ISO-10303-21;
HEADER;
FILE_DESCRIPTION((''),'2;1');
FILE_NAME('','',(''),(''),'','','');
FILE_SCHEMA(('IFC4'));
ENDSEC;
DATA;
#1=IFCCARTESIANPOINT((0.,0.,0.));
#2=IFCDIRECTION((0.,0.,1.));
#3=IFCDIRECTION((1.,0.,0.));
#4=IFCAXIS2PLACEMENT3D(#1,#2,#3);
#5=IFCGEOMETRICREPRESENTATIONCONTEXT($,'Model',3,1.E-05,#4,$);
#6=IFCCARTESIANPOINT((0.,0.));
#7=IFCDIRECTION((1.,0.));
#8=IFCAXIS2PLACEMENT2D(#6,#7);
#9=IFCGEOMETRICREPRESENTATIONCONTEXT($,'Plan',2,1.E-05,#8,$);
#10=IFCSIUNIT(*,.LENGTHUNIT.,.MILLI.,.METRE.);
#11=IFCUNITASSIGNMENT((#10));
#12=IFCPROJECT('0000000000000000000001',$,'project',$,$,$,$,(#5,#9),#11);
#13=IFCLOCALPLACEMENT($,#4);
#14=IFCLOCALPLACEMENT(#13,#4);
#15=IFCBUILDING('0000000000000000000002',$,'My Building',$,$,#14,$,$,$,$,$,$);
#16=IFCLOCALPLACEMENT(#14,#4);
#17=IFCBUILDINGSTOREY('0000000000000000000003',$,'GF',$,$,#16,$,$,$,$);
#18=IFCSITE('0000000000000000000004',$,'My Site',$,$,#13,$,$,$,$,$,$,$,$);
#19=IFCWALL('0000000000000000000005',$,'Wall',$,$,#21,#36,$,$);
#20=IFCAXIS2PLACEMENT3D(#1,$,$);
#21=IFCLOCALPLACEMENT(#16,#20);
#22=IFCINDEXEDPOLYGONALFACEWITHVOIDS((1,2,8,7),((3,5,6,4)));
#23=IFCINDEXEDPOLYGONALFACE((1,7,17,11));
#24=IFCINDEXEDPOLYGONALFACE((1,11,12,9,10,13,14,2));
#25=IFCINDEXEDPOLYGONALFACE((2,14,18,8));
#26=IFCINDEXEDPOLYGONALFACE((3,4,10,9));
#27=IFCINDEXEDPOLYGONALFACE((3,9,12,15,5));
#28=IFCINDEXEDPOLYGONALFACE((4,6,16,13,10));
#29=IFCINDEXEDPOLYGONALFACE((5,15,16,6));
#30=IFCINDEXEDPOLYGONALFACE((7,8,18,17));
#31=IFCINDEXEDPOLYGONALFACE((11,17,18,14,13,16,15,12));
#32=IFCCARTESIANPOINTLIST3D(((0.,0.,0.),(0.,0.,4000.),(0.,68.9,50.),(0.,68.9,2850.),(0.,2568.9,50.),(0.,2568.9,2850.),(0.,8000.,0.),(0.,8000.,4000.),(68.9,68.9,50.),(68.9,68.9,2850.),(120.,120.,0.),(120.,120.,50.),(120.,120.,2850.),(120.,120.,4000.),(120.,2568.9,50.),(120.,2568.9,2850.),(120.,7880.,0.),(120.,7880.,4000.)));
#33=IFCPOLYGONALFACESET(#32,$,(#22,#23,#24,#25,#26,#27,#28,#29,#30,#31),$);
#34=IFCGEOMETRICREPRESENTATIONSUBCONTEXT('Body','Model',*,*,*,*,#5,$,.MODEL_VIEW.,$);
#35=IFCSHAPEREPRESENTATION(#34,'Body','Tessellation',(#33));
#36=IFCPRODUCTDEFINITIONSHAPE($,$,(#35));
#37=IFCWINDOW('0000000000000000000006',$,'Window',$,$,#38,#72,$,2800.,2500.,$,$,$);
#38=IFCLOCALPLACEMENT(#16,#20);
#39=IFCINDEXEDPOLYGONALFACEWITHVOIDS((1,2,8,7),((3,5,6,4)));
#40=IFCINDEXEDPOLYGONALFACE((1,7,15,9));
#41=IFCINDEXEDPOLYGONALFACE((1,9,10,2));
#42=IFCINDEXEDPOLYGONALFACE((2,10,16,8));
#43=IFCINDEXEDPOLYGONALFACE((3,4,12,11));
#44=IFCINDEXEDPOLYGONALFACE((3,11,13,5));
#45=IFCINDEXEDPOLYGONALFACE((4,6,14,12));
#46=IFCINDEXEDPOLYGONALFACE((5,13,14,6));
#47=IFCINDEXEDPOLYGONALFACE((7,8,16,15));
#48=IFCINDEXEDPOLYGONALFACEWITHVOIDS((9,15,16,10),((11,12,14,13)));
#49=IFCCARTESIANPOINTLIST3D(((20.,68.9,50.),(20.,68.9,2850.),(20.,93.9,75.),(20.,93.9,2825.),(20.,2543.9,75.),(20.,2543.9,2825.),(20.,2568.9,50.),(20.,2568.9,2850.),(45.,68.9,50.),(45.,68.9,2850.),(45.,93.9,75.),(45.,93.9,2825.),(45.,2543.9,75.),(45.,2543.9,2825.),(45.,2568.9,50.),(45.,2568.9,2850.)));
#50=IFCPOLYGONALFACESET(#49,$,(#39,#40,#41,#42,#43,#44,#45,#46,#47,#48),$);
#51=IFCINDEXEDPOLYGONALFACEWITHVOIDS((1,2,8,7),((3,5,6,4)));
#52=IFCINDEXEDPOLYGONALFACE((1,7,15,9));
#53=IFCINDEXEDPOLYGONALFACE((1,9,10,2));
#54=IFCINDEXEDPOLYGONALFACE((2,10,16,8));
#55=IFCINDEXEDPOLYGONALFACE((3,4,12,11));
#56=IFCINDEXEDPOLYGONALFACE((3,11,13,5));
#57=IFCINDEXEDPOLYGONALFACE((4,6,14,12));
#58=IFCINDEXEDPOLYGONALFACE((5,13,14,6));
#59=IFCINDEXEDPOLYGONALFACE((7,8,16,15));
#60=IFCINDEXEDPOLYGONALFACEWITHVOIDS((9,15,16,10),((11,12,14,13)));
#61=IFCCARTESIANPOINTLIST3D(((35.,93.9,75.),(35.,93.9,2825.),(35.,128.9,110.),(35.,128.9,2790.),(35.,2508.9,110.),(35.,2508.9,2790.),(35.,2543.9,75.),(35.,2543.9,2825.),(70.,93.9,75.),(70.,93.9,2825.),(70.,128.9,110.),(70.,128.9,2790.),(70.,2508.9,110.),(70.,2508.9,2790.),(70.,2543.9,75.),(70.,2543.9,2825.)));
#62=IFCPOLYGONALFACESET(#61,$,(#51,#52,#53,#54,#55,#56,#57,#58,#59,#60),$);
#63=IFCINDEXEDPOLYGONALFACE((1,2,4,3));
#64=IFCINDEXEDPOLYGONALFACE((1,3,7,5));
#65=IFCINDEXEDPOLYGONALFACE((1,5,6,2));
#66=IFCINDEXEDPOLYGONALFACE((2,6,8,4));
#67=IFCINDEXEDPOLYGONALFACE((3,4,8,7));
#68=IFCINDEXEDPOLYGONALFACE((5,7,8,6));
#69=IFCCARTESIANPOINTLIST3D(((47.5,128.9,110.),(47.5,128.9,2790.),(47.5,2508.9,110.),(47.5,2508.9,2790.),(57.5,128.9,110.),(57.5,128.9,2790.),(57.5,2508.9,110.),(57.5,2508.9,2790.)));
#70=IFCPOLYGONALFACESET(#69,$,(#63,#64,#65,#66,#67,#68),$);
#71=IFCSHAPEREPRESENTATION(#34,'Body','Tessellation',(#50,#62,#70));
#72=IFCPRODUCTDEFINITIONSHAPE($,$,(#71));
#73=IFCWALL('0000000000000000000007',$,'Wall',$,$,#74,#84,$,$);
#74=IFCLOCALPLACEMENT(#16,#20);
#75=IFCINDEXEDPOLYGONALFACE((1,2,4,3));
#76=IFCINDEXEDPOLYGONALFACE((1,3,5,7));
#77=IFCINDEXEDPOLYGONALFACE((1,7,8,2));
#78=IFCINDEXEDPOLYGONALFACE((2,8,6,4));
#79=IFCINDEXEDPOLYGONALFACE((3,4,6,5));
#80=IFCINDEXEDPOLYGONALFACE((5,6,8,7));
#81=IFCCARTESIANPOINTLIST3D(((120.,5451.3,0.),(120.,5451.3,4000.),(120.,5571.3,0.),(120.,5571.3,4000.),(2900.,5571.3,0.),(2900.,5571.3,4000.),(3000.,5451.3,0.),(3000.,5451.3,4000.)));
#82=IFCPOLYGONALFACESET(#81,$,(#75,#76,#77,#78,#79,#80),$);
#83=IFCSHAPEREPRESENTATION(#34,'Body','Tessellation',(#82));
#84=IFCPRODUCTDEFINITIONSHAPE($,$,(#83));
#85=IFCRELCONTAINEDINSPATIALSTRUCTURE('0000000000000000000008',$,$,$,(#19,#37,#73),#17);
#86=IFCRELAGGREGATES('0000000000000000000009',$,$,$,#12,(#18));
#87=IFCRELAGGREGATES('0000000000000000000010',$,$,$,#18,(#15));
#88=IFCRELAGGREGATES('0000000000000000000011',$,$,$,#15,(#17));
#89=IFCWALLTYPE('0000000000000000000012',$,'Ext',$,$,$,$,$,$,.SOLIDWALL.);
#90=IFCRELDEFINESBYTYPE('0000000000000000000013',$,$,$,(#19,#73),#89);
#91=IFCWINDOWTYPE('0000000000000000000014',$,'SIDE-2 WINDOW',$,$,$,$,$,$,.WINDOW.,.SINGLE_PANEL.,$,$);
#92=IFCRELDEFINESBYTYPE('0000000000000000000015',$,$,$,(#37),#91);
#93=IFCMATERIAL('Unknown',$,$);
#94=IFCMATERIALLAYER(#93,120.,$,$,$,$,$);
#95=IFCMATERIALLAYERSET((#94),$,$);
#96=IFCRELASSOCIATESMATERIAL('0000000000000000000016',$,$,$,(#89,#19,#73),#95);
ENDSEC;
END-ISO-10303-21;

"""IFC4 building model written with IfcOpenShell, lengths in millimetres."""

from ifc_helpers import new_model, entity, si_unit, frame, origin_with_axes, origin_2d_with_axis, place, context, subcontext, project, spatial, line, indexed_curve, outline, extrude, shape, source, transform, mapped, material, layer, layer_set, layer_usage, type_object, type_shapes, element, fill, save


model = new_model("IFC4")

# Units and contexts
model_context = context("Model", 3, precision=1e-05, world=origin_with_axes())
plan_context = context("Plan", 2, precision=1e-05, world=origin_2d_with_axis())
body_context_1 = subcontext(model_context, "Body", "Model", "MODEL_VIEW")
body_context_2 = subcontext(plan_context, "Body", "Plan", "PLAN_VIEW")
ifc_project = project(units=[si_unit("LENGTHUNIT", "METRE", prefix="MILLI")], contexts=[model_context, plan_context])

# Site, building, storey
site_placement = place(None, origin_with_axes())
site = spatial("IfcSite", under=ifc_project, at=site_placement, Name="My Site")
building_placement = place(site_placement, origin_with_axes())
building = spatial("IfcBuilding", under=site, at=building_placement, Name="My Building")
storey_placement = place(building_placement, origin_with_axes())
storey = spatial("IfcBuildingStorey", under=building, at=storey_placement, Name="GF")

# Shared definitions
ifc_material = material(Name="Unknown")

# Shared definitions
ifc_layer_1 = layer(ifc_material, 120.0)
ifc_layer_set_1 = layer_set([ifc_layer_1])
wall_type_1 = type_object("IfcWallType", Name="Ext", PredefinedType="SOLIDWALL", material=ifc_layer_set_1)

# Wall, opening, window
ifc_layer_usage_1 = layer_usage(ifc_layer_set_1, "AXIS2", "NEGATIVE", 0.0)
wall_1_placement = place(storey_placement, frame((120.0, 8000.0, 0.0), z_axis=(0.0, 0.0, 1.0), x_axis=(0.0, -1.0, 0.0)))
wall_1 = element("IfcWall", 1, at=wall_1_placement, inside=storey, type_object=wall_type_1, material=ifc_layer_usage_1, Name="Wall", context=body_context_1, shape_type="SweptSolid", body=[
    extrude(outline(indexed_curve([(0.0, -120.0), (120.0, 0.0), (7880.0, 0.0), (8000.0, -120.0)], segments=[line(1, 2, 3, 4, 1)])), origin_with_axes(), (0.0, 0.0, 1.0), 4000.0),
])
shared_shape_1 = source(origin_with_axes(), body_context_1, "Body", "SweptSolid", [
    extrude(outline(indexed_curve([(0.0, 0.0), (2500.0, 0.0), (2500.0, 2800.0), (0.0, 2800.0)], segments=[line(1, 2, 3, 4, 1)])), frame((0.0, -600.0, 0.0), z_axis=(0.0, -1.0, 0.0), x_axis=(1.0, 0.0, 0.0)), (0.0, 0.0, -1.0), 1200.0),
])
opening_1_placement = place(wall_1_placement, frame((5431.1, -100.0, 50.0), z_axis=(0.0, 0.0, 1.0), x_axis=(1.0, 0.0, 0.0)))
opening_1 = element("IfcOpeningElement", 2, at=opening_1_placement, cuts=wall_1, PredefinedType="OPENING", context=body_context_1, shape_type="MappedRepresentation", body=[
    mapped(shared_shape_1, transform((0.0, 0.0, 0.0), x_axis=(1.0, 0.0, 0.0), y_axis=(0.0, 1.0, 0.0), z_axis=(0.0, 0.0, 1.0), scale=1.0)),
])
window_type_1 = type_object("IfcWindowType", Name="SIDE-2 WINDOW", PartitioningType="SINGLE_PANEL", PredefinedType="WINDOW")
shared_shape_2 = source(origin_with_axes(), body_context_1, "Body", "SweptSolid", [
    extrude(outline(indexed_curve([(0.0, 0.0), (2500.0, 0.0), (2500.0, 2800.0), (0.0, 2800.0)], segments=[line(1, 2, 3, 4, 1)]), holes=[indexed_curve([(25.0, 25.0), (2475.0, 25.0), (2475.0, 2775.0), (25.0, 2775.0)], segments=[line(1, 2, 3, 4, 1)])]), frame((0.0, 0.0, 0.0), z_axis=(0.0, -1.0, 0.0), x_axis=(1.0, 0.0, 0.0)), (0.0, 0.0, -1.0), 25.0),
    extrude(outline(indexed_curve([(0.0, 0.0), (2450.0, 0.0), (2450.0, 2750.0), (0.0, 2750.0)], segments=[line(1, 2, 3, 4, 1)]), holes=[indexed_curve([(35.0, 35.0), (2415.0, 35.0), (2415.0, 2715.0), (35.0, 2715.0)], segments=[line(1, 2, 3, 4, 1)])]), frame((25.0, 15.0, 25.0), z_axis=(0.0, -1.0, 0.0), x_axis=(1.0, 0.0, 0.0)), (0.0, 0.0, -1.0), 35.0),
    extrude(outline(indexed_curve([(35.0, 35.0), (2415.0, 35.0), (2415.0, 2715.0), (35.0, 2715.0)], segments=[line(1, 2, 3, 4, 1)])), frame((25.0, 27.5, 25.0), z_axis=(0.0, -1.0, 0.0), x_axis=(1.0, 0.0, 0.0)), (0.0, 0.0, -1.0), 10.0),
])
shared_shape_3 = source(origin_with_axes(), body_context_2, "Body", "Curve2D", [
    entity("IfcIndexedPolyCurve", entity("IfcCartesianPointList2D", [[25.0, 0.0], [2475.0, 0.0]])),
    entity("IfcIndexedPolyCurve", entity("IfcCartesianPointList2D", [[0.0, 25.0], [25.0, 25.0], [25.0, 0.0], [0.0, 0.0]]), [entity("IfcLineIndex", [1, 2, 3, 4, 1])]),
    entity("IfcIndexedPolyCurve", entity("IfcCartesianPointList2D", [[2500.0, 25.0], [2475.0, 25.0], [2475.0, 0.0], [2500.0, 0.0]]), [entity("IfcLineIndex", [1, 2, 3, 4, 1])]),
    entity("IfcIndexedPolyCurve", entity("IfcCartesianPointList2D", [[25.0, 15.0], [60.0, 15.0], [60.0, 50.0], [25.0, 50.0]]), [entity("IfcLineIndex", [1, 2, 3, 4, 1])]),
    entity("IfcIndexedPolyCurve", entity("IfcCartesianPointList2D", [[2475.0, 15.0], [2440.0, 15.0], [2440.0, 50.0], [2475.0, 50.0]]), [entity("IfcLineIndex", [1, 2, 3, 4, 1])]),
    entity("IfcIndexedPolyCurve", entity("IfcCartesianPointList2D", [[60.0, 15.0], [2440.0, 15.0]])),
    entity("IfcIndexedPolyCurve", entity("IfcCartesianPointList2D", [[60.0, 50.0], [2440.0, 50.0]])),
    entity("IfcIndexedPolyCurve", entity("IfcCartesianPointList2D", [[60.0, 32.5], [2440.0, 32.5]])),
])
type_shapes(window_type_1, [shared_shape_2, shared_shape_3])
window_1_placement = place(opening_1_placement, frame((0.0, 0.0, 0.0), z_axis=(0.0, 0.0, 1.0), x_axis=(1.0, 0.0, 0.0)))
window_1 = element("IfcWindow", 3, at=window_1_placement, inside=storey, type_object=window_type_1, Name="Window", OverallHeight=2800.0, OverallWidth=2500.0, shapes=[
    shape(body_context_1, "Body", "MappedRepresentation", [mapped(shared_shape_2, transform((0.0, 0.0, 0.0), x_axis=(1.0, 0.0, 0.0), y_axis=(0.0, 1.0, 0.0), z_axis=(0.0, 0.0, 1.0), scale=1.0))]),
    shape(body_context_2, "Body", "MappedRepresentation", [mapped(shared_shape_3, transform((0.0, 0.0, 0.0), x_axis=(1.0, 0.0, 0.0), y_axis=(0.0, 1.0, 0.0), z_axis=(0.0, 0.0, 1.0), scale=1.0))]),
])
fill(opening_1, window_1)

# Wall
ifc_layer_usage_2 = layer_usage(ifc_layer_set_1, "AXIS2", "POSITIVE", 0.0)
wall_2_placement = place(storey_placement, frame((3000.0, 5571.3, 0.0), z_axis=(0.0, 0.0, 1.0), x_axis=(-1.0, 0.0, 0.0)))
element("IfcWall", 4, at=wall_2_placement, inside=storey, type_object=wall_type_1, material=ifc_layer_usage_2, Name="Wall", context=body_context_1, shape_type="SweptSolid", body=[
    extrude(outline(indexed_curve([(100.0, 0.0), (0.0, 120.0), (2880.0, 120.0), (2880.0, 0.0)], segments=[line(1, 2, 3, 4, 1)])), origin_with_axes(), (0.0, 0.0, 1.0), 4000.0),
])

save(model, "model.ifc")
